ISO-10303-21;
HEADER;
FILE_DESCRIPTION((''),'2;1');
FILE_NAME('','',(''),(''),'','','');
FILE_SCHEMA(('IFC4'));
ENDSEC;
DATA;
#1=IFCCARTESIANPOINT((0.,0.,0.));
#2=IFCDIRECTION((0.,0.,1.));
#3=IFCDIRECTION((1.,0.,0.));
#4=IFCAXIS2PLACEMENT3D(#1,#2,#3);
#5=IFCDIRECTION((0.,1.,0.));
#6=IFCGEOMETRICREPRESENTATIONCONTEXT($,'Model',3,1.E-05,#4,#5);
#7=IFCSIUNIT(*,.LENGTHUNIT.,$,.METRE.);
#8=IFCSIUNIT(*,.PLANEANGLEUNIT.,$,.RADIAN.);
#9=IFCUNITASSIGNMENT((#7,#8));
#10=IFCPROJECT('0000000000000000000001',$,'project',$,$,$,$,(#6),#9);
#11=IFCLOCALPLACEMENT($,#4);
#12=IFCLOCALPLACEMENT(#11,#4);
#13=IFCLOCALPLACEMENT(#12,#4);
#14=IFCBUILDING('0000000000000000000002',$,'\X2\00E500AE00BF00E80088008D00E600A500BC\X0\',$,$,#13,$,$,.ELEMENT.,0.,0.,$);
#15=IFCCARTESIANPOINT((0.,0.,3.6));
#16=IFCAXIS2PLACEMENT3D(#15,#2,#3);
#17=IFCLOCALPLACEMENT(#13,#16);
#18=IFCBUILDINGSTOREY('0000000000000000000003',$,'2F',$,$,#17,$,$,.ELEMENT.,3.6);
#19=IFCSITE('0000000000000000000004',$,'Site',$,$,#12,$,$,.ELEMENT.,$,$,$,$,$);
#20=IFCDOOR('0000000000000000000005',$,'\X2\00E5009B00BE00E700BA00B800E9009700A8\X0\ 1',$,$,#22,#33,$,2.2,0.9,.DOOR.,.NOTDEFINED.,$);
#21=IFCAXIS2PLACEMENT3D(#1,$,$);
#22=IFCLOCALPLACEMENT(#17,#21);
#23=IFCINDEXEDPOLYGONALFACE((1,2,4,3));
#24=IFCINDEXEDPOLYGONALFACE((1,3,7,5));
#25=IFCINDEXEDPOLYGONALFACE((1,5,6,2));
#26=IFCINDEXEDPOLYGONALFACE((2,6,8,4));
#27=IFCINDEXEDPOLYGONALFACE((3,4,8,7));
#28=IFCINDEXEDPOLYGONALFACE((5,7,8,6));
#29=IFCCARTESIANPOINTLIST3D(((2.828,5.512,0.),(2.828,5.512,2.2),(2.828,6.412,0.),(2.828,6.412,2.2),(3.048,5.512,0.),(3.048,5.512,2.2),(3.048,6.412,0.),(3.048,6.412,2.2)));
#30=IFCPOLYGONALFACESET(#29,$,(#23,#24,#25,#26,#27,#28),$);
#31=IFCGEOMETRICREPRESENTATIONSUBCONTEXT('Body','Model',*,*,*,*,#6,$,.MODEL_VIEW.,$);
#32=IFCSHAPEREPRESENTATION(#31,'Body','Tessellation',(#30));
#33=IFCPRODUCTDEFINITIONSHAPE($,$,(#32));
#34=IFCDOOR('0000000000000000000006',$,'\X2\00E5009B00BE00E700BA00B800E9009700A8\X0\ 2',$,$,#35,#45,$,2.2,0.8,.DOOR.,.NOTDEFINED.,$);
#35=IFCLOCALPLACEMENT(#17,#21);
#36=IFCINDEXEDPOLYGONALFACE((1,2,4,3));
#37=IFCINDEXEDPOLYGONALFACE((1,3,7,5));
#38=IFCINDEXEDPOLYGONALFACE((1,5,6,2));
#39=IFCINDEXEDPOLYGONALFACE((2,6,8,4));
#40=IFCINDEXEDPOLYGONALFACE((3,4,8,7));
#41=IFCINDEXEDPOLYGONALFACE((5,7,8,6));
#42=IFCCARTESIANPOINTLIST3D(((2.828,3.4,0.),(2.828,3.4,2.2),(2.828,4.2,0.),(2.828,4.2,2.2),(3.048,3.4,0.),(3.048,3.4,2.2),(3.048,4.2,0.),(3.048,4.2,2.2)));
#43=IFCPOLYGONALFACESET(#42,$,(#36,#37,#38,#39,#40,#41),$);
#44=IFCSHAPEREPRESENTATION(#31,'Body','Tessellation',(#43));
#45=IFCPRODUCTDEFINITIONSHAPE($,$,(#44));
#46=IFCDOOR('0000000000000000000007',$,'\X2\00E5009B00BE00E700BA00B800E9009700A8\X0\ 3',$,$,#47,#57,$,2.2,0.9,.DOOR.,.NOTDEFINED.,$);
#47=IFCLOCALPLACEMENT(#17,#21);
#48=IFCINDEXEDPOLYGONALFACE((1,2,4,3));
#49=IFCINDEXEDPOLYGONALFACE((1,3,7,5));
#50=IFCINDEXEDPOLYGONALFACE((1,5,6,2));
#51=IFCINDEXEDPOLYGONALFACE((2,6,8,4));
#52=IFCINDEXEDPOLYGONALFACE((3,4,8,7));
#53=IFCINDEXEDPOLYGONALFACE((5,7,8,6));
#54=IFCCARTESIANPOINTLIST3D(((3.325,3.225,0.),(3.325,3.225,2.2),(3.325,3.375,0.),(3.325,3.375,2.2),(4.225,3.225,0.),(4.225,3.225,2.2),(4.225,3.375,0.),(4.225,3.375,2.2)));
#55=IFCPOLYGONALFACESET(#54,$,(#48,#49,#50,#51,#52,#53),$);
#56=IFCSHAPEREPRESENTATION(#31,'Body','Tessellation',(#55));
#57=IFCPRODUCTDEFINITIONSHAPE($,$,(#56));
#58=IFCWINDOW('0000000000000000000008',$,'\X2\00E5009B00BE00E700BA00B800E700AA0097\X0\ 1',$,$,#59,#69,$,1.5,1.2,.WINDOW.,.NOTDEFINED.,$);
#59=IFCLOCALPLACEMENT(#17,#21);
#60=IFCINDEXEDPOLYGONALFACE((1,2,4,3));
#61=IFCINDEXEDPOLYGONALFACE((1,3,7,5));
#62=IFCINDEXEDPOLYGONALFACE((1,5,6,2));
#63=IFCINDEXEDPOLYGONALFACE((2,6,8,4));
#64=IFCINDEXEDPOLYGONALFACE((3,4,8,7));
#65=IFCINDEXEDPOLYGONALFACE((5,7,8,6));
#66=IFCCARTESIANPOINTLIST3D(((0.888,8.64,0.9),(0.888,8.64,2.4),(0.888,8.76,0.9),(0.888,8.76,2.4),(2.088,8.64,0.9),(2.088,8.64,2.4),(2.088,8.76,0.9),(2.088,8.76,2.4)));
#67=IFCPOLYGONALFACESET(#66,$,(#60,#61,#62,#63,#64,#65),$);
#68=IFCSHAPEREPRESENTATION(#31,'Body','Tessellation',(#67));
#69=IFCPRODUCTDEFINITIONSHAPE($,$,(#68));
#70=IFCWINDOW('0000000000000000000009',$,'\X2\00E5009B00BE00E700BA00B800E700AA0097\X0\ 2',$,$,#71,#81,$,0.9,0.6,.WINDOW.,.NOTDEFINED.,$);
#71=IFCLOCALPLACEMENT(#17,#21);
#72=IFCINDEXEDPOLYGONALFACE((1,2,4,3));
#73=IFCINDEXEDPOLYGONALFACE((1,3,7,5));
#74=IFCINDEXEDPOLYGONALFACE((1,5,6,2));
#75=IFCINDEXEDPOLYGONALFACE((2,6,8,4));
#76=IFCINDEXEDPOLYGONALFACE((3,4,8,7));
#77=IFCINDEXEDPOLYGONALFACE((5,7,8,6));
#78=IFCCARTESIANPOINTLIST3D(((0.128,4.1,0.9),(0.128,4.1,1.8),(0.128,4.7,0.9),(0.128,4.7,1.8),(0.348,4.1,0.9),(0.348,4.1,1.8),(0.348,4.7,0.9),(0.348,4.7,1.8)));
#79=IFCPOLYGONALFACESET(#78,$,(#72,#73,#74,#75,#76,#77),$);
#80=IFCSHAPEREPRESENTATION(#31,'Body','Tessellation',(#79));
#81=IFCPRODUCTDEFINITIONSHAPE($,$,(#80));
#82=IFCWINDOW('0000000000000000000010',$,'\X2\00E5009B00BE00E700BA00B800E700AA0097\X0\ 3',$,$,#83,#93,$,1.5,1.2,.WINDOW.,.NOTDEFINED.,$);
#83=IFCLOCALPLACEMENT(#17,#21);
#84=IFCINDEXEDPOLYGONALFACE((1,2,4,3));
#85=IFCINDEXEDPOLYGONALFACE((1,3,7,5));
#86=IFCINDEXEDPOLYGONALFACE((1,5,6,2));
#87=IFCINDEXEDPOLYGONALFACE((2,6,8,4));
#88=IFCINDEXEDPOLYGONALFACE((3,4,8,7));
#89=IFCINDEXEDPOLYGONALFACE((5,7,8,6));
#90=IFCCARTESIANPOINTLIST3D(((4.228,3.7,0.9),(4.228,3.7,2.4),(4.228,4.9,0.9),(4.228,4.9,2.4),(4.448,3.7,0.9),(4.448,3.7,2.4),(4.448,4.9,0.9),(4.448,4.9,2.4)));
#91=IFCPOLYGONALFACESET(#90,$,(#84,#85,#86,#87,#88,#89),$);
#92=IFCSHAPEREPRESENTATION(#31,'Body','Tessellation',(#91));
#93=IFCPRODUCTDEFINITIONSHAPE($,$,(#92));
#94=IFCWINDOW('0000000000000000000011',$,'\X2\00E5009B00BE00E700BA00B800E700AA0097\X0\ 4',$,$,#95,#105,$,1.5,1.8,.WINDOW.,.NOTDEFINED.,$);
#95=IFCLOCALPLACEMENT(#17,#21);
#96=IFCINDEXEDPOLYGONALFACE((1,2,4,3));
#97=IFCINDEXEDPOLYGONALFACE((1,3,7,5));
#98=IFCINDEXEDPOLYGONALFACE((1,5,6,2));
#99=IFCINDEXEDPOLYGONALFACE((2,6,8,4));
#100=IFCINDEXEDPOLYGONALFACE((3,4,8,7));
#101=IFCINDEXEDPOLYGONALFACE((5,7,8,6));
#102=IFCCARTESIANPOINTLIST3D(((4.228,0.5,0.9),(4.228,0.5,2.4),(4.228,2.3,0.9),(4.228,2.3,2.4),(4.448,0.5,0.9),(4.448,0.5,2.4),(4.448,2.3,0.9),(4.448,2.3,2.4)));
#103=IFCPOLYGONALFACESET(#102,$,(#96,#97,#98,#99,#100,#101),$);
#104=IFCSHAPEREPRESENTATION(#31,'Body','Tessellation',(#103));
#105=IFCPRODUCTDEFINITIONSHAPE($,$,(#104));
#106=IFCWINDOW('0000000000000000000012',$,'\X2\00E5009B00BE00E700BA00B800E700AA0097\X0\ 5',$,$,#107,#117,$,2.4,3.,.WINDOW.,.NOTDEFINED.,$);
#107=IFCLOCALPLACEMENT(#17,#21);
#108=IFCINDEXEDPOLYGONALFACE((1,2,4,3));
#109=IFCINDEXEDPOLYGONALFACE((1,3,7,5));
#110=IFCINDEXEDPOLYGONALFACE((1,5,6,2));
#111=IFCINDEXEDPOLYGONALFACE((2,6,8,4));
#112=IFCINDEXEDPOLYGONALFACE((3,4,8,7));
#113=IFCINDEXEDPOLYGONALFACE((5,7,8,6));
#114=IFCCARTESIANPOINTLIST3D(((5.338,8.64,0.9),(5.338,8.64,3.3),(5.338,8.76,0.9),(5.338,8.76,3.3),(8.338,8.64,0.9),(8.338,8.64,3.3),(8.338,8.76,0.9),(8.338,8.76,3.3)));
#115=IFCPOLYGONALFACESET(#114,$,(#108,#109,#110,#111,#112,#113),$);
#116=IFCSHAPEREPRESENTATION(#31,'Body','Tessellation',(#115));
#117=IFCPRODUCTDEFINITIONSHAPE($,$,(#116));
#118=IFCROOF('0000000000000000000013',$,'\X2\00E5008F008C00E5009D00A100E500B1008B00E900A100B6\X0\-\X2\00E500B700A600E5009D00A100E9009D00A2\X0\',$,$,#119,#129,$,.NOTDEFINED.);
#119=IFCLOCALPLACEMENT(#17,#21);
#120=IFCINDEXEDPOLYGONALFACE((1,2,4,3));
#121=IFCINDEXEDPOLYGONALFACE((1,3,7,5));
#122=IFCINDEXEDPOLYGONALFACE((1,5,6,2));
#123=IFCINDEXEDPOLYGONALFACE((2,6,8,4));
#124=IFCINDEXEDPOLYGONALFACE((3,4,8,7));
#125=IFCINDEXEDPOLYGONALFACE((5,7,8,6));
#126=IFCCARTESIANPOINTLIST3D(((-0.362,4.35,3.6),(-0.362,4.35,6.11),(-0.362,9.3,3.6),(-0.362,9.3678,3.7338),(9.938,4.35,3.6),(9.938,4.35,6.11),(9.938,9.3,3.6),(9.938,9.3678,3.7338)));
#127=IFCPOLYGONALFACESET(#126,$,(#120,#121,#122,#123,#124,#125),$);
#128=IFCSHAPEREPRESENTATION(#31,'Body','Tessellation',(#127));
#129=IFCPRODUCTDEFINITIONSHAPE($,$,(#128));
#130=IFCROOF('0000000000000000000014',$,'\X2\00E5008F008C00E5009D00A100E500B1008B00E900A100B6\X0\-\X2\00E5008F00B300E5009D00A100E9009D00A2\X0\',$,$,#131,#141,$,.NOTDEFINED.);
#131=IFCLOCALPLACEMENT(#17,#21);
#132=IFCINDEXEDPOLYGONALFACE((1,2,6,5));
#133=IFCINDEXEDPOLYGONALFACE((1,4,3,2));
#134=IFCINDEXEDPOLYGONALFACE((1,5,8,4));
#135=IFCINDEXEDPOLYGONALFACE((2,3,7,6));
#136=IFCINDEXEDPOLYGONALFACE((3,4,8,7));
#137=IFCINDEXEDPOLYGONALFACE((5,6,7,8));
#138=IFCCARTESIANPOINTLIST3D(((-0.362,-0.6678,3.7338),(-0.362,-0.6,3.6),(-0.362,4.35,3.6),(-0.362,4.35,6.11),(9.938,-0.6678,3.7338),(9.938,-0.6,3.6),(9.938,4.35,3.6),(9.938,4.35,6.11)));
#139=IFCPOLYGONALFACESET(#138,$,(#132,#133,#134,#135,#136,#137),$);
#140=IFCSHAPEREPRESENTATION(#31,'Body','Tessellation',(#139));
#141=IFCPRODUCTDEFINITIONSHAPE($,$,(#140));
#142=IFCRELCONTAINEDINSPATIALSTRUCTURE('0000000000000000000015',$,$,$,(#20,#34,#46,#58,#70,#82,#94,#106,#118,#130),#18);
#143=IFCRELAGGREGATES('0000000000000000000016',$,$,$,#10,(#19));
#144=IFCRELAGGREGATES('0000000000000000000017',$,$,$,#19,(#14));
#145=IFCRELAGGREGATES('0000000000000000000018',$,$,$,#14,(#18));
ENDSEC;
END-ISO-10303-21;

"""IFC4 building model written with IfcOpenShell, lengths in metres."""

from ifc_helpers import new_model, si_unit, direction, frame, frame_2d, origin_with_axes, place, context, subcontext, project, spatial, polyline, rectangle, outline, extrude, element, save


model = new_model("IFC4")

# Units and contexts
model_context = context("Model", 3, precision=1e-05, world=origin_with_axes(), true_north=direction((0.0, 1.0, 0.0)))
body_context = subcontext(model_context, "Body", "Model", "MODEL_VIEW")
ifc_project = project(units=[si_unit("LENGTHUNIT", "METRE"), si_unit("PLANEANGLEUNIT", "RADIAN")], contexts=[model_context])

# Site, building, storey
placement = place(None, origin_with_axes())
site_placement = place(placement, origin_with_axes())
site = spatial("IfcSite", under=ifc_project, at=site_placement, Name="Site", CompositionType="ELEMENT")
building_placement = place(site_placement, origin_with_axes())
building = spatial("IfcBuilding", under=site, at=building_placement, Name="å®¿è\u0088\u008dæ¥¼", CompositionType="ELEMENT", ElevationOfRefHeight=0.0, ElevationOfTerrain=0.0)
storey_placement = place(building_placement, frame((0.0, 0.0, 3.6), z_axis=(0.0, 0.0, 1.0), x_axis=(1.0, 0.0, 0.0)))
storey = spatial("IfcBuildingStorey", under=building, at=storey_placement, Name="2F", CompositionType="ELEMENT", Elevation=3.6)

# Doors
door_1_placement = place(storey_placement, frame((2.938, 5.962, 0.0), z_axis=(0.0, 0.0, 1.0), x_axis=(0.0, 1.0, 0.0)))
element("IfcDoor", 1, at=door_1_placement, inside=storey, Name="å\u009b¾çº¸é\u0097¨ 1", OperationType="NOTDEFINED", OverallHeight=2.2, OverallWidth=0.9, PredefinedType="DOOR", context=body_context, shape_type="SweptSolid", body=[
    extrude(rectangle(XDim=0.9, YDim=0.22, at=frame_2d((0.0, 0.0), x_axis=(1.0, 0.0, 0.0))), frame((0.0, 0.0, 0.0), z_axis=(0.0, 0.0, 1.0)), (0.0, 0.0, 1.0), 2.2),
])
door_2_placement = place(storey_placement, frame((2.938, 3.8, 0.0), z_axis=(0.0, 0.0, 1.0), x_axis=(0.0, 1.0, 0.0)))
element("IfcDoor", 2, at=door_2_placement, inside=storey, Name="å\u009b¾çº¸é\u0097¨ 2", OperationType="NOTDEFINED", OverallHeight=2.2, OverallWidth=0.8, PredefinedType="DOOR", context=body_context, shape_type="SweptSolid", body=[
    extrude(rectangle(XDim=0.8, YDim=0.22, at=frame_2d((0.0, 0.0), x_axis=(1.0, 0.0, 0.0))), frame((0.0, 0.0, 0.0), z_axis=(0.0, 0.0, 1.0)), (0.0, 0.0, 1.0), 2.2),
])
door_3_placement = place(storey_placement, frame((3.775, 3.3, 0.0), z_axis=(0.0, 0.0, 1.0), x_axis=(1.0, 0.0, 0.0)))
element("IfcDoor", 3, at=door_3_placement, inside=storey, Name="å\u009b¾çº¸é\u0097¨ 3", OperationType="NOTDEFINED", OverallHeight=2.2, OverallWidth=0.9, PredefinedType="DOOR", context=body_context, shape_type="SweptSolid", body=[
    extrude(rectangle(XDim=0.9, YDim=0.15, at=frame_2d((0.0, 0.0), x_axis=(1.0, 0.0, 0.0))), frame((0.0, 0.0, 0.0), z_axis=(0.0, 0.0, 1.0)), (0.0, 0.0, 1.0), 2.2),
])

# Windows
window_1_placement = place(storey_placement, frame((1.488, 8.7, 0.9), z_axis=(0.0, 0.0, 1.0), x_axis=(1.0, 0.0, 0.0)))
element("IfcWindow", 4, at=window_1_placement, inside=storey, Name="å\u009b¾çº¸çª\u0097 1", OverallHeight=1.5, OverallWidth=1.2, PartitioningType="NOTDEFINED", PredefinedType="WINDOW", context=body_context, shape_type="SweptSolid", body=[
    extrude(rectangle(XDim=1.2, YDim=0.12, at=frame_2d((0.0, 0.0), x_axis=(1.0, 0.0, 0.0))), frame((0.0, 0.0, 0.0), z_axis=(0.0, 0.0, 1.0)), (0.0, 0.0, 1.0), 1.5),
])
window_2_placement = place(storey_placement, frame((0.238, 4.4, 0.9), z_axis=(0.0, 0.0, 1.0), x_axis=(0.0, 1.0, 0.0)))
element("IfcWindow", 5, at=window_2_placement, inside=storey, Name="å\u009b¾çº¸çª\u0097 2", OverallHeight=0.9, OverallWidth=0.6, PartitioningType="NOTDEFINED", PredefinedType="WINDOW", context=body_context, shape_type="SweptSolid", body=[
    extrude(rectangle(XDim=0.6, YDim=0.22, at=frame_2d((0.0, 0.0), x_axis=(1.0, 0.0, 0.0))), frame((0.0, 0.0, 0.0), z_axis=(0.0, 0.0, 1.0)), (0.0, 0.0, 1.0), 0.9),
])
window_3_placement = place(storey_placement, frame((4.338, 4.3, 0.9), z_axis=(0.0, 0.0, 1.0), x_axis=(0.0, 1.0, 0.0)))
element("IfcWindow", 6, at=window_3_placement, inside=storey, Name="å\u009b¾çº¸çª\u0097 3", OverallHeight=1.5, OverallWidth=1.2, PartitioningType="NOTDEFINED", PredefinedType="WINDOW", context=body_context, shape_type="SweptSolid", body=[
    extrude(rectangle(XDim=1.2, YDim=0.22, at=frame_2d((0.0, 0.0), x_axis=(1.0, 0.0, 0.0))), frame((0.0, 0.0, 0.0), z_axis=(0.0, 0.0, 1.0)), (0.0, 0.0, 1.0), 1.5),
])
window_4_placement = place(storey_placement, frame((4.338, 1.4, 0.9), z_axis=(0.0, 0.0, 1.0), x_axis=(0.0, 1.0, 0.0)))
element("IfcWindow", 7, at=window_4_placement, inside=storey, Name="å\u009b¾çº¸çª\u0097 4", OverallHeight=1.5, OverallWidth=1.8, PartitioningType="NOTDEFINED", PredefinedType="WINDOW", context=body_context, shape_type="SweptSolid", body=[
    extrude(rectangle(XDim=1.8, YDim=0.22, at=frame_2d((0.0, 0.0), x_axis=(1.0, 0.0, 0.0))), frame((0.0, 0.0, 0.0), z_axis=(0.0, 0.0, 1.0)), (0.0, 0.0, 1.0), 1.5),
])
window_5_placement = place(storey_placement, frame((6.838, 8.7, 0.9), z_axis=(0.0, 0.0, 1.0), x_axis=(-1.0, 0.0, 0.0)))
element("IfcWindow", 8, at=window_5_placement, inside=storey, Name="å\u009b¾çº¸çª\u0097 5", OverallHeight=2.4, OverallWidth=3.0, PartitioningType="NOTDEFINED", PredefinedType="WINDOW", context=body_context, shape_type="SweptSolid", body=[
    extrude(rectangle(XDim=3.0, YDim=0.12, at=frame_2d((0.0, 0.0), x_axis=(1.0, 0.0, 0.0))), frame((0.0, 0.0, 0.0), z_axis=(0.0, 0.0, 1.0)), (0.0, 0.0, 1.0), 2.4),
])

# Roofs
roof_1_placement = place(storey_placement, frame((4.788, 4.35, 3.6), z_axis=(0.0, 0.0, 1.0), x_axis=(1.0, 0.0, 0.0)))
element("IfcRoof", 9, at=roof_1_placement, inside=storey, Name="å\u008f\u008cå\u009d¡å±\u008bé¡¶-å·¦å\u009d¡é\u009d¢", PredefinedType="NOTDEFINED", context=body_context, shape_type="SweptSolid", body=[
    extrude(outline(polyline([(0.0, 0.0), (4.95, 0.0), (5.0178, 0.1338), (0.0, 2.51), (0.0, 0.0)])), frame((-5.15, 0.0, 0.0), z_axis=(1.0, 0.0, 0.0), x_axis=(0.0, 1.0, 0.0)), (0.0, 0.0, 1.0), 10.3),
])
roof_2_placement = place(storey_placement, frame((4.788, 4.35, 3.6), z_axis=(0.0, 0.0, 1.0), x_axis=(1.0, 0.0, 0.0)))
element("IfcRoof", 10, at=roof_2_placement, inside=storey, Name="å\u008f\u008cå\u009d¡å±\u008bé¡¶-å\u008f³å\u009d¡é\u009d¢", PredefinedType="NOTDEFINED", context=body_context, shape_type="SweptSolid", body=[
    extrude(outline(polyline([(0.0, 0.0), (-4.95, 0.0), (-5.0178, 0.1338), (0.0, 2.51), (0.0, 0.0)])), frame((-5.15, 0.0, 0.0), z_axis=(1.0, 0.0, 0.0), x_axis=(0.0, 1.0, 0.0)), (0.0, 0.0, 1.0), 10.3),
])

save(model, "model.ifc")
